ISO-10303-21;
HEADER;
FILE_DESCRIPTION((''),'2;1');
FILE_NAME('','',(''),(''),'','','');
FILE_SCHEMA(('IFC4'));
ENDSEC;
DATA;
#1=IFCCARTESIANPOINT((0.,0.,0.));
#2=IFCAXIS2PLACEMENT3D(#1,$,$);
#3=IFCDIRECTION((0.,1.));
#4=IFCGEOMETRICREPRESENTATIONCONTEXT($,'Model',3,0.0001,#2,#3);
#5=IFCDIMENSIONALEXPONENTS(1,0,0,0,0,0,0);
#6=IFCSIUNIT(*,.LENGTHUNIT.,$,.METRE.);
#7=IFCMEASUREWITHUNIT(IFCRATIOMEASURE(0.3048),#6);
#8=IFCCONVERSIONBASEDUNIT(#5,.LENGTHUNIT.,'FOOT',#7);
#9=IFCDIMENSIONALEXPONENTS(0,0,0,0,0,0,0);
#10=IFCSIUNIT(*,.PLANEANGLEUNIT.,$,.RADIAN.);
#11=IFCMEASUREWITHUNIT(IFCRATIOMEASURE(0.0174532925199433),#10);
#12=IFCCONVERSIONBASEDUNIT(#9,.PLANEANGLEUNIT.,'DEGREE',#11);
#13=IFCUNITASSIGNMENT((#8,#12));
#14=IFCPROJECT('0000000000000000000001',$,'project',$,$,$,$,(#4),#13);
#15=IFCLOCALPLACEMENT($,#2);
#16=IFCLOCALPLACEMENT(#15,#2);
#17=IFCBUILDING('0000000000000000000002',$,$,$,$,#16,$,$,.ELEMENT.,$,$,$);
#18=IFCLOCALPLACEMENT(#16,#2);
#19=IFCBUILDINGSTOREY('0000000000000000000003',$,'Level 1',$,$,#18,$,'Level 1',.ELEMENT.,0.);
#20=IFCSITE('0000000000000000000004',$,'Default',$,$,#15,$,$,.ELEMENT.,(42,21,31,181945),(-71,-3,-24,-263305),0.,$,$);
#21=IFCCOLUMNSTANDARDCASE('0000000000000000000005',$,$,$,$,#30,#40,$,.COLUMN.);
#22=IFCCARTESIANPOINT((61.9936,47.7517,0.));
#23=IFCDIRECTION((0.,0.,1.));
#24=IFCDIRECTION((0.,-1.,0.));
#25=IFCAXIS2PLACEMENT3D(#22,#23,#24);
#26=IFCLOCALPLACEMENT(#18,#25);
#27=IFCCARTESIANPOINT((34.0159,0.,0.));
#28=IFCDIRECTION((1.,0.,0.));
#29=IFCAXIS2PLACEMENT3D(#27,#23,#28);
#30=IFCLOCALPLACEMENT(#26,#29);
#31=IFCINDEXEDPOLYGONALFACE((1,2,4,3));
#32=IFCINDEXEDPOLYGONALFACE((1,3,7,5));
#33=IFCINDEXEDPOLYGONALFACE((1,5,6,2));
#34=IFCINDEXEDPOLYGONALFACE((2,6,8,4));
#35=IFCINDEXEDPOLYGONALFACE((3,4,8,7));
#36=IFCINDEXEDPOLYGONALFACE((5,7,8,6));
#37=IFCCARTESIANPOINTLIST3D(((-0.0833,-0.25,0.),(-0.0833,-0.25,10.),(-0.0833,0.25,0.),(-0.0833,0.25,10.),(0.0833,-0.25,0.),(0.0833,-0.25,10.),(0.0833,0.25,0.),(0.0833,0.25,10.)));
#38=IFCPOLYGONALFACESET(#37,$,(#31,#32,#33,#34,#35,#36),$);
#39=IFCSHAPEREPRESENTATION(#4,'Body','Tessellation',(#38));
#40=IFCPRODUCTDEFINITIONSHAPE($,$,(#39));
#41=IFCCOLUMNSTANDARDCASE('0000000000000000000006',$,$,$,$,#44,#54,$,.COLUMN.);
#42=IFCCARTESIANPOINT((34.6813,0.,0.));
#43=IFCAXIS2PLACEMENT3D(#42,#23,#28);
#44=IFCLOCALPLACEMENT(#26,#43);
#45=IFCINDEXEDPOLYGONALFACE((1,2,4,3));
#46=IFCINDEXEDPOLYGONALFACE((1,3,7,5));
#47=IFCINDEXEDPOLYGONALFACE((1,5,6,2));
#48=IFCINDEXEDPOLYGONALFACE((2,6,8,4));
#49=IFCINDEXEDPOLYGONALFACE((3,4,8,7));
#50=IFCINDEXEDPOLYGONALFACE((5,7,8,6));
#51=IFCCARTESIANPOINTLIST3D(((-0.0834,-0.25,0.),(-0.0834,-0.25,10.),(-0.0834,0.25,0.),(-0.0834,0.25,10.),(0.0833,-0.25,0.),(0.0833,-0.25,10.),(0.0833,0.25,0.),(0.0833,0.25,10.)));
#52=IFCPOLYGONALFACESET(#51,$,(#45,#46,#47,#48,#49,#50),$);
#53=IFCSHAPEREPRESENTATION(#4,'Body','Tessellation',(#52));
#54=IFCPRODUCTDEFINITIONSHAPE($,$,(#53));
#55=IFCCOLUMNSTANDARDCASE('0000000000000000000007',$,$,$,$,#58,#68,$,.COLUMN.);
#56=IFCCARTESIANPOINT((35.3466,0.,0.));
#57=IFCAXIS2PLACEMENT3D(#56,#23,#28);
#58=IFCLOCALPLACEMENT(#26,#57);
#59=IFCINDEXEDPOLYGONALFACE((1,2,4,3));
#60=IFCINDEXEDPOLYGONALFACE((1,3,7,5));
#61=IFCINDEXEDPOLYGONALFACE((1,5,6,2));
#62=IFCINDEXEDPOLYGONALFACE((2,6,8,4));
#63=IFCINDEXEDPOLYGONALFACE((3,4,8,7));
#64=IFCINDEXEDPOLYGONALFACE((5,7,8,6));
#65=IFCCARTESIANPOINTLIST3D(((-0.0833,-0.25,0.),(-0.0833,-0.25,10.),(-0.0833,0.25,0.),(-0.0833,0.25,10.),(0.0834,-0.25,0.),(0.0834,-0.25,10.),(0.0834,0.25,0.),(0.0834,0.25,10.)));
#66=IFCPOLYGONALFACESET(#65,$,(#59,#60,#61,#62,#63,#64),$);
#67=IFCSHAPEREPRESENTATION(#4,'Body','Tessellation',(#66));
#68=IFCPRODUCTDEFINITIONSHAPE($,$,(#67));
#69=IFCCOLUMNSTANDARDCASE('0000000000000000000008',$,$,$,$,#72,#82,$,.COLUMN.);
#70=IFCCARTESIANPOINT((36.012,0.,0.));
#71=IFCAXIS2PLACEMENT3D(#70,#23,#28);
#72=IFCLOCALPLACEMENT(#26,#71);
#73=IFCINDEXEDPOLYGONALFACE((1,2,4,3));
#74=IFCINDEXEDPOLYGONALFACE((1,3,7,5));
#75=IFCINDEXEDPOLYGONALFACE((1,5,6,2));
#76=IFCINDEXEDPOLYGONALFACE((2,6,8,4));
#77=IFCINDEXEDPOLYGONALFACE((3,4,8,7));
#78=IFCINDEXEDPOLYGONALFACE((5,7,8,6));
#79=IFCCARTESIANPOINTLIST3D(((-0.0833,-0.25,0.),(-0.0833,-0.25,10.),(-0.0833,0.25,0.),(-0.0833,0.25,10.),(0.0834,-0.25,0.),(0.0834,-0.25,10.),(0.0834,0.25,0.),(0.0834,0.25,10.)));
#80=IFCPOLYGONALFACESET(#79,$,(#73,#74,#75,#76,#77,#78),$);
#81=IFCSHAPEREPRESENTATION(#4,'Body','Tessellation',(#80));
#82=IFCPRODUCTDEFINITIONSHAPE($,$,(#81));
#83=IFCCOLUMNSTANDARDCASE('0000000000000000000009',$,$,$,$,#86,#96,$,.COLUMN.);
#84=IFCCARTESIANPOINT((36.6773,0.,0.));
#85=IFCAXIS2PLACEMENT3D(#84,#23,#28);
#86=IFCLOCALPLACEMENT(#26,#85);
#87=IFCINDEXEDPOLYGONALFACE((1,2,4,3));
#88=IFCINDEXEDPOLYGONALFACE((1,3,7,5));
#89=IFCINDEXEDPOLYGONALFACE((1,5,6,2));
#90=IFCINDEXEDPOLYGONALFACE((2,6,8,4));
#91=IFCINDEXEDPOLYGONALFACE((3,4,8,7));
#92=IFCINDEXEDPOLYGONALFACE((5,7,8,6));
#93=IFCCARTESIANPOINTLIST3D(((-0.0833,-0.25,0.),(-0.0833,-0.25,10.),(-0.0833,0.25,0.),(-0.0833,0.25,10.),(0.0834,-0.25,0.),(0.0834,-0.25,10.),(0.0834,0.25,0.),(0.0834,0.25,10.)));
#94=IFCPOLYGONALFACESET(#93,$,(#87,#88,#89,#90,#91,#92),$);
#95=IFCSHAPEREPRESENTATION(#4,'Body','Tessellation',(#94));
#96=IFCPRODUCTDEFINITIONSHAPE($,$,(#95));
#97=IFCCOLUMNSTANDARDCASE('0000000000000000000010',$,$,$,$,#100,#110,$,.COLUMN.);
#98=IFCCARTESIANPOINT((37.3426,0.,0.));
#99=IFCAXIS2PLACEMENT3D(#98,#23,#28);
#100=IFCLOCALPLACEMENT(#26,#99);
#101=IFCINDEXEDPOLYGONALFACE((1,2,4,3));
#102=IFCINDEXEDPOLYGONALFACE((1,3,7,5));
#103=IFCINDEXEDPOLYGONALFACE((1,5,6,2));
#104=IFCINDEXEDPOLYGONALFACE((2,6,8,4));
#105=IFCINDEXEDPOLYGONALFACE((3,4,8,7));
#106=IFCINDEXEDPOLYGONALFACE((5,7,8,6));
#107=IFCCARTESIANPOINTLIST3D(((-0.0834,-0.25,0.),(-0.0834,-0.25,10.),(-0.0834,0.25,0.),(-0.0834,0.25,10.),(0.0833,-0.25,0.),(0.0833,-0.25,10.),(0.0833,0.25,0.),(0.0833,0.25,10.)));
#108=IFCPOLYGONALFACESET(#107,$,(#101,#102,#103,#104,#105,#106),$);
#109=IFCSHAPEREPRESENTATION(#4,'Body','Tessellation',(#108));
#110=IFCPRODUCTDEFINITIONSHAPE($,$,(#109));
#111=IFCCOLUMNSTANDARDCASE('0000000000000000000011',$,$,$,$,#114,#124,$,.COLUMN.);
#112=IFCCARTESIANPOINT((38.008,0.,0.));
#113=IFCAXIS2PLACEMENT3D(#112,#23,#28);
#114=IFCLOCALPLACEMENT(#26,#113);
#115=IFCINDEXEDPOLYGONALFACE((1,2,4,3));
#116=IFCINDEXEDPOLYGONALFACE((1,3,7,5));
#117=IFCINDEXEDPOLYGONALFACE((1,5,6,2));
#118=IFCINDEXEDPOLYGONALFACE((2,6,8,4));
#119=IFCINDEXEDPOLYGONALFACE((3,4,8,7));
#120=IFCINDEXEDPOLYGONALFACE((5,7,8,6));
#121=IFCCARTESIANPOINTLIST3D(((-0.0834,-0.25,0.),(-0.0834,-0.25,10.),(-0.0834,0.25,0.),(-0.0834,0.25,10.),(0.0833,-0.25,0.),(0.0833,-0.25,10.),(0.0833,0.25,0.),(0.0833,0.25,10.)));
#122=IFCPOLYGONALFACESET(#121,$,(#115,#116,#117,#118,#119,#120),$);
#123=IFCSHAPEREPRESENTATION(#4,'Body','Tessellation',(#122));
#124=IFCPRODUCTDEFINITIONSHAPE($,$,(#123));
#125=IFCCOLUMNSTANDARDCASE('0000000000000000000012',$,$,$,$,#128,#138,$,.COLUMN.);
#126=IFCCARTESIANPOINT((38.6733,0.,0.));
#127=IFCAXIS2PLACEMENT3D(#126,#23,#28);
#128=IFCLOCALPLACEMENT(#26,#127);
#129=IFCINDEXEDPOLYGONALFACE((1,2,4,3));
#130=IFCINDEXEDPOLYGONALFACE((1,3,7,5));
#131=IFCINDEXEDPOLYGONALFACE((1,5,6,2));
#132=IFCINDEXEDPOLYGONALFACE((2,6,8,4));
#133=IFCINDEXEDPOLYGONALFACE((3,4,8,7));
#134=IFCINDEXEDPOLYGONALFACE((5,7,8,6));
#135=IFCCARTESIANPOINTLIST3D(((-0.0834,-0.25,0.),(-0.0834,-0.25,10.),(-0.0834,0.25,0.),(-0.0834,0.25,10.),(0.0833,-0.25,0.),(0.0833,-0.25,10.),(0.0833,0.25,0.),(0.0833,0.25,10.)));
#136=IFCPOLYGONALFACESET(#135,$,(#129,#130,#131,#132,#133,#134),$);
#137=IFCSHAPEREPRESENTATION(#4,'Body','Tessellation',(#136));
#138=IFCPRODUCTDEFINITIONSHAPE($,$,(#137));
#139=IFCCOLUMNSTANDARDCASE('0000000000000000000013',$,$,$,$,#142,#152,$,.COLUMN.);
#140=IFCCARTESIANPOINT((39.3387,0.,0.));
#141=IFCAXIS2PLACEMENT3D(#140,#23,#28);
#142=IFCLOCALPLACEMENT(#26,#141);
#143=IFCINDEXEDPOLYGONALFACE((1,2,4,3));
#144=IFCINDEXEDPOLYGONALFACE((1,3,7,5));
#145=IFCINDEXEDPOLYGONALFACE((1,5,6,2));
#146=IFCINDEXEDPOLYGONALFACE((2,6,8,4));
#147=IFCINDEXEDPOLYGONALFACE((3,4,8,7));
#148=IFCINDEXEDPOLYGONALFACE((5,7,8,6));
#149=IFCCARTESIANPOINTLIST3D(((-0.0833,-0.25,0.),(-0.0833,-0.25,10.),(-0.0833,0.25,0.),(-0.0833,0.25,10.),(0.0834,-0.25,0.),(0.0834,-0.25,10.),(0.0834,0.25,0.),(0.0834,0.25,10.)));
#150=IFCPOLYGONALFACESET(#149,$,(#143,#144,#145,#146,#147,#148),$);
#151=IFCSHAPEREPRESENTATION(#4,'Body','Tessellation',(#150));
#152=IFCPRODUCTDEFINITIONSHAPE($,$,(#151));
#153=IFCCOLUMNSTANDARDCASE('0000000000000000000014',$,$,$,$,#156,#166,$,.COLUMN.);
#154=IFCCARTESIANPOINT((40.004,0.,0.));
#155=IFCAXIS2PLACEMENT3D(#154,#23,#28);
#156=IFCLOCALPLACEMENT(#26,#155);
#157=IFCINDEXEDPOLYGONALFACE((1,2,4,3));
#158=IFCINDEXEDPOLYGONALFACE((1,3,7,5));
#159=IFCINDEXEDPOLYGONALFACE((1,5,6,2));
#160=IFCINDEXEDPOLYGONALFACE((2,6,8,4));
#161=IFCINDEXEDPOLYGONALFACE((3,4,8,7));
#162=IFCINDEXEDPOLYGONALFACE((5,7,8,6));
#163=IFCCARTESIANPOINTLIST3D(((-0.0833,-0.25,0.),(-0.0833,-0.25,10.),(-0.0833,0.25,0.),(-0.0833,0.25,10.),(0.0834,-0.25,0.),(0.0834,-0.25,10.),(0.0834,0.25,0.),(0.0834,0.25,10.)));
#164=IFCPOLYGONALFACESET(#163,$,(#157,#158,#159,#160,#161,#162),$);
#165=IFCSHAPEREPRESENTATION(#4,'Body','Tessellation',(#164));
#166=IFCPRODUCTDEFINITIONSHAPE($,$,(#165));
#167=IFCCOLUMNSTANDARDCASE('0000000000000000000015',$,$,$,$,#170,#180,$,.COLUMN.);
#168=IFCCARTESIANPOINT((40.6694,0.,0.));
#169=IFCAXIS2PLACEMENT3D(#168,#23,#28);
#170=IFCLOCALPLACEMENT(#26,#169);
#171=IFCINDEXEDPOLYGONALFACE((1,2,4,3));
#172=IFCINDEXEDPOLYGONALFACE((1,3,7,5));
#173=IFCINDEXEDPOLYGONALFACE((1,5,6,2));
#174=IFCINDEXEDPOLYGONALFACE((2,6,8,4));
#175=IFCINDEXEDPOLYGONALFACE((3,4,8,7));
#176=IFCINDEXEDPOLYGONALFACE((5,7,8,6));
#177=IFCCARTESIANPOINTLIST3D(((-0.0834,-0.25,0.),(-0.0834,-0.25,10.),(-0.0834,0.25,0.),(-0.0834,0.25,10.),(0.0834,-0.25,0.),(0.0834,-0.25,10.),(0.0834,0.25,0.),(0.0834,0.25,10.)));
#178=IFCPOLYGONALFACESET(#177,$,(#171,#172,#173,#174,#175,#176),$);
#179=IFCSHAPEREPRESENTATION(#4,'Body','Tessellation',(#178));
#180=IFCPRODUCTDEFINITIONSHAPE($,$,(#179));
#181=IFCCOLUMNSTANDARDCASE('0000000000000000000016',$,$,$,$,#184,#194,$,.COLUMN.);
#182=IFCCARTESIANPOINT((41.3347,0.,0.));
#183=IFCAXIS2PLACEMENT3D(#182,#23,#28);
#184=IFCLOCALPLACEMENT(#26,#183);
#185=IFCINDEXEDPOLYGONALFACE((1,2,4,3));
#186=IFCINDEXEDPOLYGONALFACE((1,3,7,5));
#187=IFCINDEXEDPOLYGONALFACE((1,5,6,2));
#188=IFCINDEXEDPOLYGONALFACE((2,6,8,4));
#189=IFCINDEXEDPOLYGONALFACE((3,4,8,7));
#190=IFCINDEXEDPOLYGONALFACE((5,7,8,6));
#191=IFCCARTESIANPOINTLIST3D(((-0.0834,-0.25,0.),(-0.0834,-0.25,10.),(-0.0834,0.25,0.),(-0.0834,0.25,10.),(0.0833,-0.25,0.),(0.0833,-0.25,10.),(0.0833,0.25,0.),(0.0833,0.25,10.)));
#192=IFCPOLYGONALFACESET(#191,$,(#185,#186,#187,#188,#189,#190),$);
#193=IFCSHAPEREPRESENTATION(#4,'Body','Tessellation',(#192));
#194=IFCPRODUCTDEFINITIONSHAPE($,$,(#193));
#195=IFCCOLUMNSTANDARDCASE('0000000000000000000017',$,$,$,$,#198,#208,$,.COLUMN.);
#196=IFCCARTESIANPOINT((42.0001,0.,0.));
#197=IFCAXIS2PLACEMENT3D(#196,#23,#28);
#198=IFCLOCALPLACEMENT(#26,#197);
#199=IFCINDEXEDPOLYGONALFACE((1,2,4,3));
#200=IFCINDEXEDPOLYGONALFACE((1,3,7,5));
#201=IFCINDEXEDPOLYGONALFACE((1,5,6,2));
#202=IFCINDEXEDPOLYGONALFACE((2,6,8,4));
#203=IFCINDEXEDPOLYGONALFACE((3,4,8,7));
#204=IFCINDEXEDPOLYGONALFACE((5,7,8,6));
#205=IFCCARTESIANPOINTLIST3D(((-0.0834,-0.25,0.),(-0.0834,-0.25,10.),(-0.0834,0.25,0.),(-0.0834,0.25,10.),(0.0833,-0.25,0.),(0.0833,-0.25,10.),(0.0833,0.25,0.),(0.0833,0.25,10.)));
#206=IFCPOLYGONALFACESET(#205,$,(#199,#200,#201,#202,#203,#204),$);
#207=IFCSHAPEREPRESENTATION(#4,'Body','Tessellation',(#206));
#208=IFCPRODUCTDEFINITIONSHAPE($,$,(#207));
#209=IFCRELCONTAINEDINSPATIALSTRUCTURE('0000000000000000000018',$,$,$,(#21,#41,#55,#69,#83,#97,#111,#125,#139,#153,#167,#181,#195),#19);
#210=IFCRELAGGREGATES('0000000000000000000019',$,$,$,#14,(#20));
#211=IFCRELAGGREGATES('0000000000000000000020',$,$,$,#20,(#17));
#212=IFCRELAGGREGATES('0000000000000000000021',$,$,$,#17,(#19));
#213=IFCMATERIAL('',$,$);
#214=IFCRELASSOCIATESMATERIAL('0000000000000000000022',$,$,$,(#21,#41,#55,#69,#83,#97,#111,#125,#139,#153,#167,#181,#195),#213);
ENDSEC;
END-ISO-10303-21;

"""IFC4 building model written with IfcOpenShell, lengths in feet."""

from ifc_helpers import new_model, entity, si_unit, converted_unit, direction, frame, origin, place, context, project, spatial, rectangle, extrude, material, element, save


model = new_model("IFC4")

# Units and contexts
model_context = context("Model", 3, precision=0.0001, world=origin(), true_north=direction((0.0, 1.0)))
ifc_project = project(units=[converted_unit("LENGTHUNIT", "FOOT", entity("IfcRatioMeasure", 0.3048), si_unit("LENGTHUNIT", "METRE"), dimensions=[1, 0, 0, 0, 0, 0, 0]), converted_unit("PLANEANGLEUNIT", "DEGREE", entity("IfcRatioMeasure", 0.0174532925199433), si_unit("PLANEANGLEUNIT", "RADIAN"), dimensions=[0, 0, 0, 0, 0, 0, 0])], contexts=[model_context])

# Site, building, storey
site_placement = place(None, origin())
site = spatial("IfcSite", under=ifc_project, at=site_placement, Name="Default", CompositionType="ELEMENT", RefLatitude=(42, 21, 31, 181945), RefLongitude=(-71, -3, -24, -263305), RefElevation=0.0)
building_placement = place(site_placement, origin())
building = spatial("IfcBuilding", under=site, at=building_placement, CompositionType="ELEMENT")
storey_placement = place(building_placement, origin())
storey = spatial("IfcBuildingStorey", under=building, at=storey_placement, Name="Level 1", LongName="Level 1", CompositionType="ELEMENT", Elevation=0.0)

# Columns
ifc_material_1 = material(Name="")
placement = place(storey_placement, frame((61.9936, 47.7517, 0.0), z_axis=(0.0, 0.0, 1.0), x_axis=(0.0, -1.0, 0.0)))
for number, where, z_axis, x_axis in (
    (1, (34.0159, 0.0, 0.0), (0.0, 0.0, 1.0), (1.0, 0.0, 0.0)),
    (2, (34.6813, 0.0, 0.0), (0.0, 0.0, 1.0), (1.0, 0.0, 0.0)),
    (3, (35.3466, 0.0, 0.0), (0.0, 0.0, 1.0), (1.0, 0.0, 0.0)),
    (4, (36.012, 0.0, 0.0), (0.0, 0.0, 1.0), (1.0, 0.0, 0.0)),
    (5, (36.6773, 0.0, 0.0), (0.0, 0.0, 1.0), (1.0, 0.0, 0.0)),
    (6, (37.3426, 0.0, 0.0), (0.0, 0.0, 1.0), (1.0, 0.0, 0.0)),
    (7, (38.008, 0.0, 0.0), (0.0, 0.0, 1.0), (1.0, 0.0, 0.0)),
    (8, (38.6733, 0.0, 0.0), (0.0, 0.0, 1.0), (1.0, 0.0, 0.0)),
    (9, (39.3387, 0.0, 0.0), (0.0, 0.0, 1.0), (1.0, 0.0, 0.0)),
    (10, (40.004, 0.0, 0.0), (0.0, 0.0, 1.0), (1.0, 0.0, 0.0)),
    (11, (40.6694, 0.0, 0.0), (0.0, 0.0, 1.0), (1.0, 0.0, 0.0)),
    (12, (41.3347, 0.0, 0.0), (0.0, 0.0, 1.0), (1.0, 0.0, 0.0)),
    (13, (42.0001, 0.0, 0.0), (0.0, 0.0, 1.0), (1.0, 0.0, 0.0)),
):
    element("IfcColumnStandardCase", number, at=place(placement, frame(where, z_axis=z_axis, x_axis=x_axis)), inside=storey, material=ifc_material_1, PredefinedType="COLUMN", context=model_context, shape_type="SweptSolid", body=[
        extrude(rectangle(XDim=0.1667, YDim=0.5), origin(), (0.0, 0.0, 1.0), 10.0),
    ])

save(model, "model.ifc")
